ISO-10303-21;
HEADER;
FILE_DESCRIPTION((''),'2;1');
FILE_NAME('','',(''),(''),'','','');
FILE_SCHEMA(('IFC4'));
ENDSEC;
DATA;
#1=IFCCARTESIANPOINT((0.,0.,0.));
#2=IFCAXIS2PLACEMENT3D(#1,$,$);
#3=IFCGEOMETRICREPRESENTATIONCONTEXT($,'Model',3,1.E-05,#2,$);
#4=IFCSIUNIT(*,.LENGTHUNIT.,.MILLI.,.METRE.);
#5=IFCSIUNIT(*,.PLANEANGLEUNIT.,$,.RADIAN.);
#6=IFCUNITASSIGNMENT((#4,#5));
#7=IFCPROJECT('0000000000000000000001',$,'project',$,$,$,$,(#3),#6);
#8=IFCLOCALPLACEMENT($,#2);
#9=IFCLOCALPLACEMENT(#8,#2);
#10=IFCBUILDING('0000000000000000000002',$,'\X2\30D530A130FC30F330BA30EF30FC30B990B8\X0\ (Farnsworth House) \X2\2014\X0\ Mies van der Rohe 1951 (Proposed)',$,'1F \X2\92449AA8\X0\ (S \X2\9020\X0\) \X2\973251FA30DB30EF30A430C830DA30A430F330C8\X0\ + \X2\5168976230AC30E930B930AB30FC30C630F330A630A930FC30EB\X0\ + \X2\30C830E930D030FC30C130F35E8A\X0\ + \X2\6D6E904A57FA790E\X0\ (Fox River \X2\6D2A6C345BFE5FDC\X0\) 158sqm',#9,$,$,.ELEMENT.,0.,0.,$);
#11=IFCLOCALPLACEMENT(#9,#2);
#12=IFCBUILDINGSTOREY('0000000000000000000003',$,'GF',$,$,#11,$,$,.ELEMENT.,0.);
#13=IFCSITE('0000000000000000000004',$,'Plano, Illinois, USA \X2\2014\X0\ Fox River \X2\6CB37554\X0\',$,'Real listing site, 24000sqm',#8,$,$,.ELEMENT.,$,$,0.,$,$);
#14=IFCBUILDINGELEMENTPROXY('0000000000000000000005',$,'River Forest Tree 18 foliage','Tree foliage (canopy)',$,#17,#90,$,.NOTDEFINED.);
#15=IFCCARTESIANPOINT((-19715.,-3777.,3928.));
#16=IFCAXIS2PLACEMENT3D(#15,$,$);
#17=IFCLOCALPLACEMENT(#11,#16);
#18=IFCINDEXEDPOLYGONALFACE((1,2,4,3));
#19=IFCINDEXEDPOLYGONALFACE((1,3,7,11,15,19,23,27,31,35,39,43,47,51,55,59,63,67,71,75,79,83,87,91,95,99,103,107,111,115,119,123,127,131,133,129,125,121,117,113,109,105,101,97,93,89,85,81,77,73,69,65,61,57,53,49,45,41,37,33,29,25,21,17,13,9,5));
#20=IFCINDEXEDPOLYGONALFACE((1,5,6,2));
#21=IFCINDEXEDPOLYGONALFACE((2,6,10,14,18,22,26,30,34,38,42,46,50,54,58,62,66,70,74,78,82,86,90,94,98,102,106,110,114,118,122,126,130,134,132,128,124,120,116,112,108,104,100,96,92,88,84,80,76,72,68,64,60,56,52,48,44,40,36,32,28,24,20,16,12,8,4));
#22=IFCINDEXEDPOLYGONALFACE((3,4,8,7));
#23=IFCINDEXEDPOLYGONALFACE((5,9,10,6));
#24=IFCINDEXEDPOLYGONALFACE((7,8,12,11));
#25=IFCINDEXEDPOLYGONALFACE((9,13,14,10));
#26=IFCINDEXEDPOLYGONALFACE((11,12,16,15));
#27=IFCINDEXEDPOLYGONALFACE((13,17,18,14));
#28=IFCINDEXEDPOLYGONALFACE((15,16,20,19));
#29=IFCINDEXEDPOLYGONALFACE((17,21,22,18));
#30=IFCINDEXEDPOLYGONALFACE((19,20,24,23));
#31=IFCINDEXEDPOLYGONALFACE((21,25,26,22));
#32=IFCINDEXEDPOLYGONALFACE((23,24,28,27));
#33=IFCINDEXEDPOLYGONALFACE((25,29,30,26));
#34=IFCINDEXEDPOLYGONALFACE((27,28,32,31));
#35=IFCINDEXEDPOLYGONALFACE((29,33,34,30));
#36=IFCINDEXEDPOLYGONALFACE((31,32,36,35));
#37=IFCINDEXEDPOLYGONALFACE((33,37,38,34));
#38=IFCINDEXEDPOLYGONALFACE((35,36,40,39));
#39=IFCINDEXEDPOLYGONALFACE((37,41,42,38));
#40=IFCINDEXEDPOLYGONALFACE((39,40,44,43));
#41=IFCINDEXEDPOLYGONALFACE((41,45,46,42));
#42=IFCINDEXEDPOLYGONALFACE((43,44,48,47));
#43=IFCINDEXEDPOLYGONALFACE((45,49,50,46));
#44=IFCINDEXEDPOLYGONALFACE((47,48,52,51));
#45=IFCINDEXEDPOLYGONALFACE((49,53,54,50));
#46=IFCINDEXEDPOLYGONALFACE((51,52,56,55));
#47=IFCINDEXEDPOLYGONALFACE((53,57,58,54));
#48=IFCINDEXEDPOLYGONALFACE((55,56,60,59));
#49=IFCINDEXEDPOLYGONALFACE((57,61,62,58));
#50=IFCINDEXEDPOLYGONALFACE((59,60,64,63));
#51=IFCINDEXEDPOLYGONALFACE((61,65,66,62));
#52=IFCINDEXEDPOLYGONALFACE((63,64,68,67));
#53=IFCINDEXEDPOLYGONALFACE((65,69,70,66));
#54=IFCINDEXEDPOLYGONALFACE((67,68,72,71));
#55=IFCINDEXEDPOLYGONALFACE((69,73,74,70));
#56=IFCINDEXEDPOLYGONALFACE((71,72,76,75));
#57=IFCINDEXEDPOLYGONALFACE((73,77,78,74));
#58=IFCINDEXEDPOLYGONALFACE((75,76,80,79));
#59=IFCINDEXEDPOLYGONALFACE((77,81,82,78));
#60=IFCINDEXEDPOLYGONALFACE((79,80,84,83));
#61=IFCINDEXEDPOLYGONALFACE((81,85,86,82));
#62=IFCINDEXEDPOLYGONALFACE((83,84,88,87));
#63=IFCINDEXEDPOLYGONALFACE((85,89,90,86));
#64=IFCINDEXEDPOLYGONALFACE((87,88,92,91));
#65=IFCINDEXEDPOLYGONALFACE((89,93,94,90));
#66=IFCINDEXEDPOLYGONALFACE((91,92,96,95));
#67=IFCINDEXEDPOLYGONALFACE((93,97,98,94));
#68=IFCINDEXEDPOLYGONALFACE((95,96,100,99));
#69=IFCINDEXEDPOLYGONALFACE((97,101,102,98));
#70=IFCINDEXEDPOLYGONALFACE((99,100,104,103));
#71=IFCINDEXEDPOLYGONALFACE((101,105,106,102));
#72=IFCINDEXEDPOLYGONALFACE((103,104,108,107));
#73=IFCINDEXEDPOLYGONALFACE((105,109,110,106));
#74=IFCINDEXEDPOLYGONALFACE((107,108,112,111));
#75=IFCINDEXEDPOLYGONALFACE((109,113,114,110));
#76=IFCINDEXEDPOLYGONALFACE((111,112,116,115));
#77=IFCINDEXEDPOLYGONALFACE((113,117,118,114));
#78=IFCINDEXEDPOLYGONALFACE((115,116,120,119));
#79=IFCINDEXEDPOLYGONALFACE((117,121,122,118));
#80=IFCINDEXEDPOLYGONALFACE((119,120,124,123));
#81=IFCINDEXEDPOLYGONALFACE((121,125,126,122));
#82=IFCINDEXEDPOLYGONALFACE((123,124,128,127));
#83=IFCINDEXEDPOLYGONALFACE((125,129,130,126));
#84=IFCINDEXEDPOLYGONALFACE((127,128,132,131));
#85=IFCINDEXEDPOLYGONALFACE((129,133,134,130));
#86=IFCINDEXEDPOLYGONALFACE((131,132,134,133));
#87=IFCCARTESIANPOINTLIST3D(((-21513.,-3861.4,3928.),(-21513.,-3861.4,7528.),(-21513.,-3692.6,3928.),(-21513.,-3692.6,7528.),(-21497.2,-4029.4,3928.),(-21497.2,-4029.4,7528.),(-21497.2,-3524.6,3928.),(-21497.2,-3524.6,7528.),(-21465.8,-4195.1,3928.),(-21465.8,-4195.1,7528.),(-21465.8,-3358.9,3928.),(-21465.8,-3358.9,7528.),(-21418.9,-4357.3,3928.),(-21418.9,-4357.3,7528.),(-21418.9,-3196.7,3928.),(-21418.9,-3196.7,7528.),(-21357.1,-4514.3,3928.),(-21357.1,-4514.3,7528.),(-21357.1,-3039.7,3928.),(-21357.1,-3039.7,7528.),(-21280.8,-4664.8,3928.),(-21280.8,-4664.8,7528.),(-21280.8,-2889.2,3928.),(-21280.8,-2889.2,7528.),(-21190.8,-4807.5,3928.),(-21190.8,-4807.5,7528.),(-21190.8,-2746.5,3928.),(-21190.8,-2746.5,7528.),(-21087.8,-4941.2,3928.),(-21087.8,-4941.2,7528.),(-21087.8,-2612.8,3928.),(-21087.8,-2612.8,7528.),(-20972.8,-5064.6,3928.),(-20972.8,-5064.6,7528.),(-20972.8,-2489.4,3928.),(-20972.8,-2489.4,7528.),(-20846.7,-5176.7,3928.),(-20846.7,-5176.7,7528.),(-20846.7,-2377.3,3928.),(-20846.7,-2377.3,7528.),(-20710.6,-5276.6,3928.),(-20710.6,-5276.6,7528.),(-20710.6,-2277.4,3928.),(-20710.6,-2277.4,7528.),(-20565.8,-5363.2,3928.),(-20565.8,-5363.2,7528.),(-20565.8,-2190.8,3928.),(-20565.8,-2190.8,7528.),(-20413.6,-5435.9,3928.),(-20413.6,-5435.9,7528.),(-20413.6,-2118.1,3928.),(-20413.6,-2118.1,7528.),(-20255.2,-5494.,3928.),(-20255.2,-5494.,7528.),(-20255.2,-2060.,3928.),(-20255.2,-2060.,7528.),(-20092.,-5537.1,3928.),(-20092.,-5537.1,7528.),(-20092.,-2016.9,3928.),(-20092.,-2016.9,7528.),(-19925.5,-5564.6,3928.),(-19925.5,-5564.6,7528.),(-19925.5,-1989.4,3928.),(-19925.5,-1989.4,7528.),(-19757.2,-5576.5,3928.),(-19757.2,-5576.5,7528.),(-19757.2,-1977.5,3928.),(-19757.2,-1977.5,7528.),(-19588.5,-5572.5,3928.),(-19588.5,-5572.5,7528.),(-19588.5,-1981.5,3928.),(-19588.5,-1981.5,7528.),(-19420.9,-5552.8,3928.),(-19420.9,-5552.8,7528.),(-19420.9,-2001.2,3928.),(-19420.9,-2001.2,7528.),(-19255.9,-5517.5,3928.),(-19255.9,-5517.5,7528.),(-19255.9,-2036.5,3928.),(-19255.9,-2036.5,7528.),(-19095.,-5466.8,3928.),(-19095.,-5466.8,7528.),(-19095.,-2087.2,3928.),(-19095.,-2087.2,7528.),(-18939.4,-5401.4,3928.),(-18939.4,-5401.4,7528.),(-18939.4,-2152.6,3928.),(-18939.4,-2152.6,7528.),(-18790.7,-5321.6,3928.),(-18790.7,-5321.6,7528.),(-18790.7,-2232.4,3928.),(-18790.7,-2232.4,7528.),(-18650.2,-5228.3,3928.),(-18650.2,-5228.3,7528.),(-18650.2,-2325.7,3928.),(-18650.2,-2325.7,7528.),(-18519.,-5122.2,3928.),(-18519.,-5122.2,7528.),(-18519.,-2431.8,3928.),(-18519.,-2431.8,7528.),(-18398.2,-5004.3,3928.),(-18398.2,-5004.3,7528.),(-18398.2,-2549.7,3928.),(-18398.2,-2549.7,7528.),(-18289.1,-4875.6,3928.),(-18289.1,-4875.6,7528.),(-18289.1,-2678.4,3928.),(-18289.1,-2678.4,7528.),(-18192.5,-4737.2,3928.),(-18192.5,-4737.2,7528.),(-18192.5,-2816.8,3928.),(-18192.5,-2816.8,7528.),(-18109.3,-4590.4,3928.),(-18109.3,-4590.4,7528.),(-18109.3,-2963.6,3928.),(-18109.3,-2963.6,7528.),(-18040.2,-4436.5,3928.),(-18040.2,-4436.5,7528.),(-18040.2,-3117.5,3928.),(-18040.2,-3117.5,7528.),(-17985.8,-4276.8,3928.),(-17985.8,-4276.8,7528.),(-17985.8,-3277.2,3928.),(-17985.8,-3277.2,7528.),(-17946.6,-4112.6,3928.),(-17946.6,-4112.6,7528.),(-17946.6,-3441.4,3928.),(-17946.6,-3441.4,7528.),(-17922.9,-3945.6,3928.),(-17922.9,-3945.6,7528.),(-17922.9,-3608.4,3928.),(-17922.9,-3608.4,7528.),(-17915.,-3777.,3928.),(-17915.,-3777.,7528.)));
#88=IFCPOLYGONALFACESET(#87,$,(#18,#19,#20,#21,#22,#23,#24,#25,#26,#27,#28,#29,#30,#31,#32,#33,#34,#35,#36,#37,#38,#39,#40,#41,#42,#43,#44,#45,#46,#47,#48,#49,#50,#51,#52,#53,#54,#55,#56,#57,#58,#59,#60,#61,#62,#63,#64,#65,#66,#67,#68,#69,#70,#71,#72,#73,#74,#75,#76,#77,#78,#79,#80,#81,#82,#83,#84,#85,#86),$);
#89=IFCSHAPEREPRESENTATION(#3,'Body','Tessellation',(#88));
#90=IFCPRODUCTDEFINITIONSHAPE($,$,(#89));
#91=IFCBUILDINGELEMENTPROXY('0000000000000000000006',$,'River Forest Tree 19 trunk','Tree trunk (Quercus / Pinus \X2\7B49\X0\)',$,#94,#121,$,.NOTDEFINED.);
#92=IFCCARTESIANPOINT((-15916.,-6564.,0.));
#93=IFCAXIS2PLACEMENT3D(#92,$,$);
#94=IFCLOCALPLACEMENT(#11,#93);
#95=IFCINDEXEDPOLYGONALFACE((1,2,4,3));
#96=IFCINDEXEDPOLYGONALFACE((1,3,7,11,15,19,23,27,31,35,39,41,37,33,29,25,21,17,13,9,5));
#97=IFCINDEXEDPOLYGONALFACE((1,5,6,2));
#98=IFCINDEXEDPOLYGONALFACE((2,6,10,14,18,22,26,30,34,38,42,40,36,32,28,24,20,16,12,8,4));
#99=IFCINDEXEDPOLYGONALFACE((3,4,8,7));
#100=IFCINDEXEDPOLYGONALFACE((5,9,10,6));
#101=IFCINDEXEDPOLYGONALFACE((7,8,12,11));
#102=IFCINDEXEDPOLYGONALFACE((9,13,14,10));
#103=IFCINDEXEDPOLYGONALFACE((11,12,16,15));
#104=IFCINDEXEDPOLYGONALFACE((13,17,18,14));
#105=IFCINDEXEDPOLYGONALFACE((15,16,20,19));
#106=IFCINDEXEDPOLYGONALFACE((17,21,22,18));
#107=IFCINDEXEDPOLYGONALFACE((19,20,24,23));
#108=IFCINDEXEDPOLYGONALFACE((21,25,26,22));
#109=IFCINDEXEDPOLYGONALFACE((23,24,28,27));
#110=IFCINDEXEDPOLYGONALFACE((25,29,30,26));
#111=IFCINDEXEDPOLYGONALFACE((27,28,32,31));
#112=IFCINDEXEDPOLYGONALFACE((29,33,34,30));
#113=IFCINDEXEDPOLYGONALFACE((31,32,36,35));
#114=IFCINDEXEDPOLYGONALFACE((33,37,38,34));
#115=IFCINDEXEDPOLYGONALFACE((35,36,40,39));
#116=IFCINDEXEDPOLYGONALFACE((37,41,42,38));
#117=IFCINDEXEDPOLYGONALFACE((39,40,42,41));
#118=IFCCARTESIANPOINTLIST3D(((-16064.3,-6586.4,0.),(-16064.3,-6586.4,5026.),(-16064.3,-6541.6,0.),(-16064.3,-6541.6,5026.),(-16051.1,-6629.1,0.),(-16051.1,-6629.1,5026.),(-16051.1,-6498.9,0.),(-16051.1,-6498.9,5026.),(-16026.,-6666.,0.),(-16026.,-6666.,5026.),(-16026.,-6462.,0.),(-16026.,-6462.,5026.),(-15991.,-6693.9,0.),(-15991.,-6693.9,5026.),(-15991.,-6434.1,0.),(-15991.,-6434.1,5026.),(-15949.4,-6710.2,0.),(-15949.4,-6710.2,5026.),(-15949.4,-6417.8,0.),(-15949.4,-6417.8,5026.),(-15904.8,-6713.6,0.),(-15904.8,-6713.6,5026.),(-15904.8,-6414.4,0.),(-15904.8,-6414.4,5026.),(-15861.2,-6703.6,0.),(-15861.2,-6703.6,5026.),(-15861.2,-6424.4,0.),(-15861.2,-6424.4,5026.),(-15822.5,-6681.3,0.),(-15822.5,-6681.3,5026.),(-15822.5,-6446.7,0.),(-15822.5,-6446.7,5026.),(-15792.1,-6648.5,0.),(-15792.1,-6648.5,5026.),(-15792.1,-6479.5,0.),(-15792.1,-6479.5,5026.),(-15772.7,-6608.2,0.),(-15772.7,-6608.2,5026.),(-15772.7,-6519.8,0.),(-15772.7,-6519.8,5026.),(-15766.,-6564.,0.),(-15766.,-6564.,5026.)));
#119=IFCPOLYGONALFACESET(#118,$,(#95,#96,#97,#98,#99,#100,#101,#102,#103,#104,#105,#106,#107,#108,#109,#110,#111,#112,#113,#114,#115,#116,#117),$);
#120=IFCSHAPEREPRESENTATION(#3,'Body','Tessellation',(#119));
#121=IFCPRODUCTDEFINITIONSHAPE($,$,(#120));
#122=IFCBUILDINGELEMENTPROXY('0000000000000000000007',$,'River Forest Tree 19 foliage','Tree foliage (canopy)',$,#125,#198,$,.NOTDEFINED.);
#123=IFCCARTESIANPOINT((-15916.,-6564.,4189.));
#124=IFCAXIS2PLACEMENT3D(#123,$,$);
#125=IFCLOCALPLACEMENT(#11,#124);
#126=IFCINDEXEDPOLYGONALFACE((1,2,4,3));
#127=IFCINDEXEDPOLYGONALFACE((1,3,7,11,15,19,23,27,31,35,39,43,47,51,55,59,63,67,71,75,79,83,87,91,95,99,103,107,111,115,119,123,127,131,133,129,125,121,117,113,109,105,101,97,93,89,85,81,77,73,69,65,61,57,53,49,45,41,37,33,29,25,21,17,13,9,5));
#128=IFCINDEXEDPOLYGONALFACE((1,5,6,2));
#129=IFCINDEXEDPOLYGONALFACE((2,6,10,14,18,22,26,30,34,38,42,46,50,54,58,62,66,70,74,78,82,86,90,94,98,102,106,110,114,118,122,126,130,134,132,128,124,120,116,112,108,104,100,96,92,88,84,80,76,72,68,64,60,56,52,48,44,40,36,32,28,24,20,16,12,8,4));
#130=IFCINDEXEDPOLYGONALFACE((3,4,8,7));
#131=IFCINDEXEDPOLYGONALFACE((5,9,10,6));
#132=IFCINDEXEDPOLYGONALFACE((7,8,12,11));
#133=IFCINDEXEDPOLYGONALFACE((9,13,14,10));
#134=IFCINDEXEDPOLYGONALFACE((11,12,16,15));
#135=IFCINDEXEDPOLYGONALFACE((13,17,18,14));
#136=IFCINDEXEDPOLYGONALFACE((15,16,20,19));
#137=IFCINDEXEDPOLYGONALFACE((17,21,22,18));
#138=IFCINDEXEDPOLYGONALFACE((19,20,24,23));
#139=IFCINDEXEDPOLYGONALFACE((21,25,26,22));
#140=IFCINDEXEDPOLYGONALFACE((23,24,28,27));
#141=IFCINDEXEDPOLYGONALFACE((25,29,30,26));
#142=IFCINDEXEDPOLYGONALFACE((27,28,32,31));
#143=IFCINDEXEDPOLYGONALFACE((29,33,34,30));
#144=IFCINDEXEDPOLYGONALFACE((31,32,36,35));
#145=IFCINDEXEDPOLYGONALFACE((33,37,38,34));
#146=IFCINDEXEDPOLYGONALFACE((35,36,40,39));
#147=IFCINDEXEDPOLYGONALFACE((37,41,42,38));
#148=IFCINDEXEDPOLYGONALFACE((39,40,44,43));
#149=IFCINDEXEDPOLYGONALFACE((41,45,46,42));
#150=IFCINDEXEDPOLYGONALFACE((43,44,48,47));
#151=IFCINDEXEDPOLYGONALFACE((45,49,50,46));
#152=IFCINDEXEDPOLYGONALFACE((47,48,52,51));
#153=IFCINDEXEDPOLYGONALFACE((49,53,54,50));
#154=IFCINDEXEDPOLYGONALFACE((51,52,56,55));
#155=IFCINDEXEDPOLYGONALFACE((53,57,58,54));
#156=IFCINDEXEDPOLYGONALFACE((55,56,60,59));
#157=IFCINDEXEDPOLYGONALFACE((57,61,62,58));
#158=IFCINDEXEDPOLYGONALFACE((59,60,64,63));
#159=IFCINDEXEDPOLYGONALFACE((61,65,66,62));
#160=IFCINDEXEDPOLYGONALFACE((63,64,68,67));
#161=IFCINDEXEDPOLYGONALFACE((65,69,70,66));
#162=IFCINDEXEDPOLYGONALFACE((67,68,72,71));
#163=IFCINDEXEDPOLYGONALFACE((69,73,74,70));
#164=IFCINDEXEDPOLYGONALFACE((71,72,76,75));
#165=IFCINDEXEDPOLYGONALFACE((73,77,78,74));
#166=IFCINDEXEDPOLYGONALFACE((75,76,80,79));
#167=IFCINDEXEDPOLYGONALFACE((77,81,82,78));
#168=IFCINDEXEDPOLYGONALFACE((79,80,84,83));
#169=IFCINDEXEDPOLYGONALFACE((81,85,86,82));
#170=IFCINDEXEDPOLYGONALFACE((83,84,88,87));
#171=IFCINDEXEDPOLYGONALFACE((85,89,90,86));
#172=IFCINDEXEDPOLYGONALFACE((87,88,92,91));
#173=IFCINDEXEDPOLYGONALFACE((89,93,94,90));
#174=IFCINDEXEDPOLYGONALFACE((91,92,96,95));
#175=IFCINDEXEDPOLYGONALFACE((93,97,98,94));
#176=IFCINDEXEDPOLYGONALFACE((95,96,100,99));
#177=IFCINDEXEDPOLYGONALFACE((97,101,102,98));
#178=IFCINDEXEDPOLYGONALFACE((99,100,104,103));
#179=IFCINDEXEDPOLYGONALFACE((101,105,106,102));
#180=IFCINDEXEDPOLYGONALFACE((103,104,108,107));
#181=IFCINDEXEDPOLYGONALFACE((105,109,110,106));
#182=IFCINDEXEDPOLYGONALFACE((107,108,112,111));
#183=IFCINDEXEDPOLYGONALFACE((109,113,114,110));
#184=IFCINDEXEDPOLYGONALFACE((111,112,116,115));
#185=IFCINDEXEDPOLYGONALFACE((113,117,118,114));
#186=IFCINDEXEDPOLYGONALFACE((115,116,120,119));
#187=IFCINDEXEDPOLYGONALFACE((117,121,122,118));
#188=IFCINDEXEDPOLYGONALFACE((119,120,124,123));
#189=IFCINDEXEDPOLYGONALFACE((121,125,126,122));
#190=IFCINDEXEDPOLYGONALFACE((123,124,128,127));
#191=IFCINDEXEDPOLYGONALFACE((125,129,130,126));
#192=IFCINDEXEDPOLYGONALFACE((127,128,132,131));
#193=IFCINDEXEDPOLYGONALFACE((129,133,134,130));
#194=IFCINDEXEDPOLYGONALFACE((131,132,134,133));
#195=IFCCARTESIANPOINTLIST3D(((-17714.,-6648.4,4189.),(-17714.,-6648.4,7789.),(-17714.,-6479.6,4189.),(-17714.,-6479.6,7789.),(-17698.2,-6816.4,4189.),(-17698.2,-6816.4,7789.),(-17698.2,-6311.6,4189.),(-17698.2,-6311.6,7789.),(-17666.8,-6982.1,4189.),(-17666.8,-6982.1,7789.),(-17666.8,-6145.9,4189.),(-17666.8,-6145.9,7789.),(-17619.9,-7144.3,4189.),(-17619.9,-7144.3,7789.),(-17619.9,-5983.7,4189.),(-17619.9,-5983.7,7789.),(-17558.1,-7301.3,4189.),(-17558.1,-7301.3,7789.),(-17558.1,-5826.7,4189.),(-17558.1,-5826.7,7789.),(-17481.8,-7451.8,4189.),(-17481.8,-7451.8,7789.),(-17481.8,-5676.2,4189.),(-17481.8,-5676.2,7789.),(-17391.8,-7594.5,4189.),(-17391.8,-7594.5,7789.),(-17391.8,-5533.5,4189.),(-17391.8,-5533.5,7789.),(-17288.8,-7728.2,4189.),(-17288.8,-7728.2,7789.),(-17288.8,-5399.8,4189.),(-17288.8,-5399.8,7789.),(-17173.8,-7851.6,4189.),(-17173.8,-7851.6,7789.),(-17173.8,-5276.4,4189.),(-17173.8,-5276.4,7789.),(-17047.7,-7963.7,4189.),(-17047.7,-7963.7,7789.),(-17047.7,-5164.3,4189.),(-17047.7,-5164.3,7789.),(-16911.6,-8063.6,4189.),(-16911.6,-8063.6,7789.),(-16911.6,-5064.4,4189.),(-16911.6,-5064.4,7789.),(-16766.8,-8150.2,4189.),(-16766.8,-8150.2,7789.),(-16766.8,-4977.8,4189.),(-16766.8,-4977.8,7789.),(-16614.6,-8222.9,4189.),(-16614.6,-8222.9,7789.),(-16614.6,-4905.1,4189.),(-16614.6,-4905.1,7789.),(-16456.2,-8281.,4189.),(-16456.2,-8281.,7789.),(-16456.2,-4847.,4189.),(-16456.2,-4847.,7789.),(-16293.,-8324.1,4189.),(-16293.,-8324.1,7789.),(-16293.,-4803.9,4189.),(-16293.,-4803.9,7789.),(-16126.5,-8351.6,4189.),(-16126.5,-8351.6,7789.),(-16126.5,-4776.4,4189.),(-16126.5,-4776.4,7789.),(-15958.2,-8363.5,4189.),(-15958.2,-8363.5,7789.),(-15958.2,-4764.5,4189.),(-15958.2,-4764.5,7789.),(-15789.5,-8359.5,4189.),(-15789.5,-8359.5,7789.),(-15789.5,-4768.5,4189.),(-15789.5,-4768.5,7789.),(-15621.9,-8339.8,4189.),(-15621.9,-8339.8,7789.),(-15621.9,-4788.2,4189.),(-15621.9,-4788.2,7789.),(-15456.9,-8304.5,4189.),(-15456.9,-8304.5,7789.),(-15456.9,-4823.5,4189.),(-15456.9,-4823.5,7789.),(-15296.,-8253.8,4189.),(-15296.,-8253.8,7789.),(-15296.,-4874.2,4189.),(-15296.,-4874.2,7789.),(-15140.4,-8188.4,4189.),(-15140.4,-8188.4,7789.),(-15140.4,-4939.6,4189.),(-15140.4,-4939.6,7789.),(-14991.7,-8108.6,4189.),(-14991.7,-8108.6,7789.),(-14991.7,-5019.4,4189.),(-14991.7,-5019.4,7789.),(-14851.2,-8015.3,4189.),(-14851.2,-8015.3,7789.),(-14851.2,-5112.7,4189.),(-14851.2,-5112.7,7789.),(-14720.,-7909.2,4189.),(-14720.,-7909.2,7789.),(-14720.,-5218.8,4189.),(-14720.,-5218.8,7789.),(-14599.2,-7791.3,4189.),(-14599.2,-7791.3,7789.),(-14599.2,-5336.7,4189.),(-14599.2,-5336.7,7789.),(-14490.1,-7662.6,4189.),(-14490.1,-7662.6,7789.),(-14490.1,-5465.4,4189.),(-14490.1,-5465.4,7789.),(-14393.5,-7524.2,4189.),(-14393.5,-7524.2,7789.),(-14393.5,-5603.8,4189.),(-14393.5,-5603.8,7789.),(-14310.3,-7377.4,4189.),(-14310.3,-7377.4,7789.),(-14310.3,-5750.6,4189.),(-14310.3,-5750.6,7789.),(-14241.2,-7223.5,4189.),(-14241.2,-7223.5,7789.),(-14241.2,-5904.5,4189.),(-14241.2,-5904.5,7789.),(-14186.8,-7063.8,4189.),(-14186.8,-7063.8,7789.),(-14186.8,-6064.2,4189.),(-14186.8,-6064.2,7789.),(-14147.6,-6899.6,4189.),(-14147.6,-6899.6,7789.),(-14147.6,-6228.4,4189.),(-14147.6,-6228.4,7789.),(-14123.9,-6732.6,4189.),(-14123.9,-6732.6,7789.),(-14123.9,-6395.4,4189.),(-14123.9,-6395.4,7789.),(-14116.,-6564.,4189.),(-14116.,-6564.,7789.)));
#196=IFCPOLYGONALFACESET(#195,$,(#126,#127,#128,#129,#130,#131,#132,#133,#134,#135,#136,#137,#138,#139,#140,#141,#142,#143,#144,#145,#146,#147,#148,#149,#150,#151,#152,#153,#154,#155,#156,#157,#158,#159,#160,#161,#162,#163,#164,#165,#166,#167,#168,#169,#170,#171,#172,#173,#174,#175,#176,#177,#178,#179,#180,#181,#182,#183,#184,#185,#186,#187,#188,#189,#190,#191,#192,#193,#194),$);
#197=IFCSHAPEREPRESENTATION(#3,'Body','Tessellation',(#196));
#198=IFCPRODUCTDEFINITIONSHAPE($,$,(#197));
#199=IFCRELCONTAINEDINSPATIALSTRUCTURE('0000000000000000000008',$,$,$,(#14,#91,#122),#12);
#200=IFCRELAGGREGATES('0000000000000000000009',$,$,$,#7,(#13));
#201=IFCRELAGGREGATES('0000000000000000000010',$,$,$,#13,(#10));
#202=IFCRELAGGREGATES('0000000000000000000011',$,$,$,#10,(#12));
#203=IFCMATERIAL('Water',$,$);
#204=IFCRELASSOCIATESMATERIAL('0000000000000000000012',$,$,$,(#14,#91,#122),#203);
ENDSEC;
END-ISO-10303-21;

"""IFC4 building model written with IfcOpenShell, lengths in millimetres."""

from ifc_helpers import new_model, si_unit, frame, origin, origin_2d, place, context, project, spatial, circle, extrude, material, element, save


model = new_model("IFC4")

# Units and contexts
model_context = context("Model", 3, precision=1e-05, world=origin())
ifc_project = project(units=[si_unit("LENGTHUNIT", "METRE", prefix="MILLI"), si_unit("PLANEANGLEUNIT", "RADIAN")], contexts=[model_context])

# Site, building, storey
site_placement = place(None, origin())
site = spatial("IfcSite", under=ifc_project, at=site_placement, Name="Plano, Illinois, USA — Fox River 河畔", ObjectType="Real listing site, 24000sqm", CompositionType="ELEMENT", RefElevation=0.0)
building_placement = place(site_placement, origin())
building = spatial("IfcBuilding", under=site, at=building_placement, Name="ファーンズワース邸 (Farnsworth House) — Mies van der Rohe 1951 (Proposed)", ObjectType="1F 鉄骨 (S 造) 露出ホワイトペイント + 全面ガラスカーテンウォール + トラバーチン床 + 浮遊基礎 (Fox River 洪水対応) 158sqm", CompositionType="ELEMENT", ElevationOfRefHeight=0.0, ElevationOfTerrain=0.0)
storey_placement = place(building_placement, origin())
storey = spatial("IfcBuildingStorey", under=building, at=storey_placement, Name="GF", CompositionType="ELEMENT", Elevation=0.0)

# Building element proxies
ifc_material_1 = material(Name="Water")
proxy_1_placement = place(storey_placement, frame((-19715.0, -3777.0, 3928.0)))
element("IfcBuildingElementProxy", 1, at=proxy_1_placement, inside=storey, material=ifc_material_1, Name="River Forest Tree 18 foliage", Description="Tree foliage (canopy)", PredefinedType="NOTDEFINED", context=model_context, shape_type="SweptSolid", body=[
    extrude(circle(Radius=1800.0, at=origin_2d()), frame((-19715.0, -3777.0, 3928.0)), (0.0, 0.0, 1.0), 3600.0),
])
proxy_2_placement = place(storey_placement, frame((-15916.0, -6564.0, 0.0)))
element("IfcBuildingElementProxy", 2, at=proxy_2_placement, inside=storey, material=ifc_material_1, Name="River Forest Tree 19 trunk", Description="Tree trunk (Quercus / Pinus 等)", PredefinedType="NOTDEFINED", context=model_context, shape_type="SweptSolid", body=[
    extrude(circle(Radius=150.0, at=origin_2d()), frame((-15916.0, -6564.0, 0.0)), (0.0, 0.0, 1.0), 5026.0),
])
proxy_3_placement = place(storey_placement, frame((-15916.0, -6564.0, 4189.0)))
element("IfcBuildingElementProxy", 3, at=proxy_3_placement, inside=storey, material=ifc_material_1, Name="River Forest Tree 19 foliage", Description="Tree foliage (canopy)", PredefinedType="NOTDEFINED", context=model_context, shape_type="SweptSolid", body=[
    extrude(circle(Radius=1800.0, at=origin_2d()), frame((-15916.0, -6564.0, 4189.0)), (0.0, 0.0, 1.0), 3600.0),
])

save(model, "model.ifc")
